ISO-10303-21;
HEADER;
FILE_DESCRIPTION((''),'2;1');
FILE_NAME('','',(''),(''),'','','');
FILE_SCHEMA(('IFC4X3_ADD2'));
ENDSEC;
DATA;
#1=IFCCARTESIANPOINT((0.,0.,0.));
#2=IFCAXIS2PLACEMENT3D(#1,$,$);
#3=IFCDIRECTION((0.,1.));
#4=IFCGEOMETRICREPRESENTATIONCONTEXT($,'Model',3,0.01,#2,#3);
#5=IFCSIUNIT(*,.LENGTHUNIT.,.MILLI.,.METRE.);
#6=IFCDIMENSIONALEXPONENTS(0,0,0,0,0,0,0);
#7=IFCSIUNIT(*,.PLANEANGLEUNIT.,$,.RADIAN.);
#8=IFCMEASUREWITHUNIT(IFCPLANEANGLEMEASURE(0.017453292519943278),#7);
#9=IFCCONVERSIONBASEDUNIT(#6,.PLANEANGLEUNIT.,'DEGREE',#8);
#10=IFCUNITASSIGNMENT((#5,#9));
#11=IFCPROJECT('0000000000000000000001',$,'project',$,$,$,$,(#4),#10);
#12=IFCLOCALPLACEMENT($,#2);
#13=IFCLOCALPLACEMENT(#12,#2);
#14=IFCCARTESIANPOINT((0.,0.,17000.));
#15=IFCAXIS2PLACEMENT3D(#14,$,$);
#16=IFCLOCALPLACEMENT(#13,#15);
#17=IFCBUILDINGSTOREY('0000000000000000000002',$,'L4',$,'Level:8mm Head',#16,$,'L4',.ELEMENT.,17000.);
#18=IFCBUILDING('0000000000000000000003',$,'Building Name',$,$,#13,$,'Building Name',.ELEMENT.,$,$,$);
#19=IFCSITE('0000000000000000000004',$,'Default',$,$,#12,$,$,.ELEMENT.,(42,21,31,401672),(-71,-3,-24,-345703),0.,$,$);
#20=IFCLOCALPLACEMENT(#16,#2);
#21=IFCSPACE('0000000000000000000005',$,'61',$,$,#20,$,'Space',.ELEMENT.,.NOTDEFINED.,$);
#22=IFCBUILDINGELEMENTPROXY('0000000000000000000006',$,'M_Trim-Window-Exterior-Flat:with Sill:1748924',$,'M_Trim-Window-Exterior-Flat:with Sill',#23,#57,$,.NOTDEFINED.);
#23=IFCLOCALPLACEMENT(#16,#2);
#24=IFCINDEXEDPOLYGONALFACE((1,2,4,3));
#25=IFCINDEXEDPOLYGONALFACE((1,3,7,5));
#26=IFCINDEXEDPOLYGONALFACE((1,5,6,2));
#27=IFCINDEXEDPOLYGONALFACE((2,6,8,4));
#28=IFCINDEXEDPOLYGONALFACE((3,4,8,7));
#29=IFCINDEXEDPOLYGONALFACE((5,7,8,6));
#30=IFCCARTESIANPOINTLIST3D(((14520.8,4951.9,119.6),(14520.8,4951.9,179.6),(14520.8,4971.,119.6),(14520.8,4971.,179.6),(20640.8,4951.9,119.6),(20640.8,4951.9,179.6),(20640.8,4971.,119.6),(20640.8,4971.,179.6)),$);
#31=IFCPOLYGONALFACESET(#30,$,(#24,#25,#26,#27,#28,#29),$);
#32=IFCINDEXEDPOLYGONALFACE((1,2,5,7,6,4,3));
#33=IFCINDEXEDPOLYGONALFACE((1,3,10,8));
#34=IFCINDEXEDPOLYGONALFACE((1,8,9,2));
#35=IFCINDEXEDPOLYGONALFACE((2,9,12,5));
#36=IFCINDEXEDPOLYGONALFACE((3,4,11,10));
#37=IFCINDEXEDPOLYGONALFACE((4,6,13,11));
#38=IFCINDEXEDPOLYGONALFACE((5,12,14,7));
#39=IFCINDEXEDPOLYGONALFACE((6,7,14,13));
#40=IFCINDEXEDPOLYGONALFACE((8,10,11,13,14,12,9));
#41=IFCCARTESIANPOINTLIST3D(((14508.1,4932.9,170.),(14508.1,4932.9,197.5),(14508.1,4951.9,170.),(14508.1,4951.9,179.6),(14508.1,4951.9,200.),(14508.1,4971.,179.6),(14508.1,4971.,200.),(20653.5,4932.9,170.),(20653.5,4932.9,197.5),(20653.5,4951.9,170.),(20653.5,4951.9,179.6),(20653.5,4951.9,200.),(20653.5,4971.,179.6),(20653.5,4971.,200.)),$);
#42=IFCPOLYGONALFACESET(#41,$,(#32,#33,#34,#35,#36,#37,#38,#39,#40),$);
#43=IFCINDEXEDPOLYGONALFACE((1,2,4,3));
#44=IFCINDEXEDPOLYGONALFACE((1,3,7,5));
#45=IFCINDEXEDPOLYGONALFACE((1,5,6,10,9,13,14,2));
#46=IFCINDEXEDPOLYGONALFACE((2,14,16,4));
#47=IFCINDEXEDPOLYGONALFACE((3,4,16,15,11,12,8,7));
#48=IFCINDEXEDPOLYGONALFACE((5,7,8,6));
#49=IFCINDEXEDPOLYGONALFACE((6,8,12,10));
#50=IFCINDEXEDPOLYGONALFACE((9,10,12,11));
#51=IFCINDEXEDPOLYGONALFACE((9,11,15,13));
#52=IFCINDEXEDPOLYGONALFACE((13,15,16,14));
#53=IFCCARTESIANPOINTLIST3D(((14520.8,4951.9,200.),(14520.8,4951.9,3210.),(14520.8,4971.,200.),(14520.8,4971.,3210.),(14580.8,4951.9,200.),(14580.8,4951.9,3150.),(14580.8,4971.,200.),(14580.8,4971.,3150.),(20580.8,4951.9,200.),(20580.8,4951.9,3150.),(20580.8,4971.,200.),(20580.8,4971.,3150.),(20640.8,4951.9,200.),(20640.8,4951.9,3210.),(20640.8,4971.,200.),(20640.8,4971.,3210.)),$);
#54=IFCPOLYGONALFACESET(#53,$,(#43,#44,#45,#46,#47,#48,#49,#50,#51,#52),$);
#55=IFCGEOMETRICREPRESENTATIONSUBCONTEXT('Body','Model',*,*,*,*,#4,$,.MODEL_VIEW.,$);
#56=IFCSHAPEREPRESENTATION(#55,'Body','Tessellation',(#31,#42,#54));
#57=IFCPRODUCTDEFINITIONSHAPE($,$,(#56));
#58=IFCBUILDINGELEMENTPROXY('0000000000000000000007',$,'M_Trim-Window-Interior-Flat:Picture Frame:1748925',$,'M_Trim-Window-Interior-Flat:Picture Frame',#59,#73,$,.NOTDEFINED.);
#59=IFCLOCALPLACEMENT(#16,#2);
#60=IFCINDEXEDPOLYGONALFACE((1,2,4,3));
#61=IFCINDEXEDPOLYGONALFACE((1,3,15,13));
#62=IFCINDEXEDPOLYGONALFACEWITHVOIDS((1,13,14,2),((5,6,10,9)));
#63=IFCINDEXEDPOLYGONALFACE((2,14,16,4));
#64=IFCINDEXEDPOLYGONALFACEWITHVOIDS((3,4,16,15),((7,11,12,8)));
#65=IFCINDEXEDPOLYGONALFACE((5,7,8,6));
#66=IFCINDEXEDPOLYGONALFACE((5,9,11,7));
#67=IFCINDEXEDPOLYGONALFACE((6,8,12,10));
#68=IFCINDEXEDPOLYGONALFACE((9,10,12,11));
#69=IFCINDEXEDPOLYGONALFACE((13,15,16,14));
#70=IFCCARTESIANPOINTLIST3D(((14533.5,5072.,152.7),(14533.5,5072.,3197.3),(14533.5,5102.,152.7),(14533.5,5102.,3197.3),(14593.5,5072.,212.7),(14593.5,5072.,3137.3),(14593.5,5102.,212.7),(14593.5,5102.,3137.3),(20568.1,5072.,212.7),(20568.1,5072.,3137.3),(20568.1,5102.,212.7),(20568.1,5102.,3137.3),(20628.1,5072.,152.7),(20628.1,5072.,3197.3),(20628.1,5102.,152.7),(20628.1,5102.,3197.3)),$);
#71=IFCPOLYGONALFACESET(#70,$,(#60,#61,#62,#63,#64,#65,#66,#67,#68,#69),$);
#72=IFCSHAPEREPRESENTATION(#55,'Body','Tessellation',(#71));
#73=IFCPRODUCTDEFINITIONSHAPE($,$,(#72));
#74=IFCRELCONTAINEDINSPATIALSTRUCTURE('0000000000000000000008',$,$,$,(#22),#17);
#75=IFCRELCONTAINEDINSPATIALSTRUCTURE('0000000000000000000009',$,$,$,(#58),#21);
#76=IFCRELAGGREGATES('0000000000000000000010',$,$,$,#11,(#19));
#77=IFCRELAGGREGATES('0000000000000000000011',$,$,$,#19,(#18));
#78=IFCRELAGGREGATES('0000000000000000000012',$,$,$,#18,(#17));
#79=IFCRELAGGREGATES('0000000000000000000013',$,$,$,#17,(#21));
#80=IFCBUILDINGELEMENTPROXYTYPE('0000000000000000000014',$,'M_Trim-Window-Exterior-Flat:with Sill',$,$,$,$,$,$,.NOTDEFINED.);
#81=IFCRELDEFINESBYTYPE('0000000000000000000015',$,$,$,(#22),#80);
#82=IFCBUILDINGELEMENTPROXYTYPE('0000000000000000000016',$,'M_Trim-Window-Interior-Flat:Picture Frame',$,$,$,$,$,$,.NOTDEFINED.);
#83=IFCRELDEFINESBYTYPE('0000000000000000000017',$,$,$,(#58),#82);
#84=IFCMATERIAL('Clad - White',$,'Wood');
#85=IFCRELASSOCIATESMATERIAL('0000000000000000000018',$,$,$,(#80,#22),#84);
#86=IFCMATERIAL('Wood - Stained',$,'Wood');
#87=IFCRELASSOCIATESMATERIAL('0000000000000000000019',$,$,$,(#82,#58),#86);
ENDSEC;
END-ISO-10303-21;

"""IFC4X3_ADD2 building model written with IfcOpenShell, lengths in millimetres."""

from ifc_helpers import new_model, entity, si_unit, converted_unit, direction, frame, frame_2d, origin, place, context, subcontext, project, spatial, polyline, rectangle, outline, extrude, source, transform, mapped, material, type_object, type_shapes, element, save


model = new_model("IFC4X3_ADD2")

# Units and contexts
model_context = context("Model", 3, precision=0.01, world=origin(), true_north=direction((0.0, 1.0)))
body_context = subcontext(model_context, "Body", "Model", "MODEL_VIEW")
ifc_project = project(units=[si_unit("LENGTHUNIT", "METRE", prefix="MILLI"), converted_unit("PLANEANGLEUNIT", "DEGREE", entity("IfcPlaneAngleMeasure", 0.017453292519943278), si_unit("PLANEANGLEUNIT", "RADIAN"), dimensions=[0, 0, 0, 0, 0, 0, 0])], contexts=[model_context])

# Site, building, storey
site_placement = place(None, origin())
site = spatial("IfcSite", under=ifc_project, at=site_placement, Name="Default", CompositionType="ELEMENT", RefLatitude=(42, 21, 31, 401672), RefLongitude=(-71, -3, -24, -345703), RefElevation=0.0)
building_placement = place(site_placement, origin())
building = spatial("IfcBuilding", under=site, at=building_placement, Name="Building Name", LongName="Building Name", CompositionType="ELEMENT")
storey_placement = place(building_placement, frame((0.0, 0.0, 17000.0)))
storey = spatial("IfcBuildingStorey", under=building, at=storey_placement, Name="L4", ObjectType="Level:8mm Head", LongName="L4", CompositionType="ELEMENT", Elevation=17000.0)

# Shared definitions
ifc_material_1 = material(Name="Clad - White", Category="Wood")
ifc_material_2 = material(Name="Wood - Stained", Category="Wood")

# Building element proxy
building_element_proxy_type_1 = type_object("IfcBuildingElementProxyType", Name="M_Trim-Window-Exterior-Flat:with Sill", PredefinedType="NOTDEFINED", material=ifc_material_1)
shared_shape_1 = source(origin(), body_context, "Body", "SweptSolid", [
    extrude(rectangle(XDim=6120.0, YDim=60.0, at=frame_2d((0.0, 0.0), x_axis=(1.0, 0.0))), frame((0.0, -3000.4, 0.0), z_axis=(0.0, 0.0, 1.0), x_axis=(-1.0, 0.0, 0.0)), (0.0, 0.0, 1.0), 19.0),
    extrude(outline(polyline([(-19.0, -15.2), (0.0, -15.2), (0.0, -5.7), (19.0, -5.7), (19.0, 14.8), (0.0, 14.8), (-19.0, 12.3), (-19.0, -15.2)])), frame((-3072.7, -2964.8, 19.1), z_axis=(1.0, 0.0, 0.0), x_axis=(0.0, 0.0, -1.0)), (0.0, 0.0, 1.0), 6145.4),
    extrude(outline(polyline([(-1520.0, -3060.0), (1490.0, -3060.0), (1490.0, -3000.0), (-1460.0, -3000.0), (-1460.0, 3000.0), (1490.0, 3000.0), (1490.0, 3060.0), (-1520.0, 3060.0), (-1520.0, -3060.0)])), frame((0.0, -1460.0, 0.0), z_axis=(0.0, 0.0, 1.0), x_axis=(0.0, -1.0, 0.0)), (0.0, 0.0, 1.0), 19.0),
])
type_shapes(building_element_proxy_type_1, [shared_shape_1])
proxy_1_placement = place(storey_placement, frame((17580.8, 4971.0, 3150.0), z_axis=(0.0, -1.0, 0.0), x_axis=(1.0, 0.0, 0.0)))
element("IfcBuildingElementProxy", 1, at=proxy_1_placement, inside=storey, type_object=building_element_proxy_type_1, material=ifc_material_1, Name="M_Trim-Window-Exterior-Flat:with Sill:1748924", ObjectType="M_Trim-Window-Exterior-Flat:with Sill", PredefinedType="NOTDEFINED", context=body_context, shape_type="MappedRepresentation", body=[
    mapped(shared_shape_1, transform((0.0, 0.0, 0.0), scale=1.0)),
])

# Shared definitions
space_1_placement = place(storey_placement, origin())
space_1 = spatial("IfcSpace", under=storey, at=space_1_placement, Name="61", LongName="Space", CompositionType="ELEMENT", PredefinedType="NOTDEFINED")

# Building element proxy
building_element_proxy_type_2 = type_object("IfcBuildingElementProxyType", Name="M_Trim-Window-Interior-Flat:Picture Frame", PredefinedType="NOTDEFINED", material=ifc_material_2)
shared_shape_2 = source(origin(), body_context, "Body", "SweptSolid", [
    extrude(outline(polyline([(-3047.3, -1522.3), (3047.3, -1522.3), (3047.3, 1522.3), (-3047.3, 1522.3), (-3047.3, -1522.3)]), holes=[polyline([(-2987.3, -1462.3), (-2987.3, 1462.3), (2987.3, 1462.3), (2987.3, -1462.3), (-2987.3, -1462.3)])]), frame((0.0, -1475.0, 0.0), z_axis=(0.0, 0.0, 1.0), x_axis=(-1.0, 0.0, 0.0)), (0.0, 0.0, 1.0), 30.0),
])
type_shapes(building_element_proxy_type_2, [shared_shape_2])
proxy_2_placement = place(space_1_placement, frame((17580.8, 5072.0, 3150.0), z_axis=(0.0, 1.0, 0.0), x_axis=(-1.0, 0.0, 0.0)))
element("IfcBuildingElementProxy", 2, at=proxy_2_placement, inside=space_1, type_object=building_element_proxy_type_2, material=ifc_material_2, Name="M_Trim-Window-Interior-Flat:Picture Frame:1748925", ObjectType="M_Trim-Window-Interior-Flat:Picture Frame", PredefinedType="NOTDEFINED", context=body_context, shape_type="MappedRepresentation", body=[
    mapped(shared_shape_2, transform((0.0, 0.0, 0.0), scale=1.0)),
])

save(model, "model.ifc")
